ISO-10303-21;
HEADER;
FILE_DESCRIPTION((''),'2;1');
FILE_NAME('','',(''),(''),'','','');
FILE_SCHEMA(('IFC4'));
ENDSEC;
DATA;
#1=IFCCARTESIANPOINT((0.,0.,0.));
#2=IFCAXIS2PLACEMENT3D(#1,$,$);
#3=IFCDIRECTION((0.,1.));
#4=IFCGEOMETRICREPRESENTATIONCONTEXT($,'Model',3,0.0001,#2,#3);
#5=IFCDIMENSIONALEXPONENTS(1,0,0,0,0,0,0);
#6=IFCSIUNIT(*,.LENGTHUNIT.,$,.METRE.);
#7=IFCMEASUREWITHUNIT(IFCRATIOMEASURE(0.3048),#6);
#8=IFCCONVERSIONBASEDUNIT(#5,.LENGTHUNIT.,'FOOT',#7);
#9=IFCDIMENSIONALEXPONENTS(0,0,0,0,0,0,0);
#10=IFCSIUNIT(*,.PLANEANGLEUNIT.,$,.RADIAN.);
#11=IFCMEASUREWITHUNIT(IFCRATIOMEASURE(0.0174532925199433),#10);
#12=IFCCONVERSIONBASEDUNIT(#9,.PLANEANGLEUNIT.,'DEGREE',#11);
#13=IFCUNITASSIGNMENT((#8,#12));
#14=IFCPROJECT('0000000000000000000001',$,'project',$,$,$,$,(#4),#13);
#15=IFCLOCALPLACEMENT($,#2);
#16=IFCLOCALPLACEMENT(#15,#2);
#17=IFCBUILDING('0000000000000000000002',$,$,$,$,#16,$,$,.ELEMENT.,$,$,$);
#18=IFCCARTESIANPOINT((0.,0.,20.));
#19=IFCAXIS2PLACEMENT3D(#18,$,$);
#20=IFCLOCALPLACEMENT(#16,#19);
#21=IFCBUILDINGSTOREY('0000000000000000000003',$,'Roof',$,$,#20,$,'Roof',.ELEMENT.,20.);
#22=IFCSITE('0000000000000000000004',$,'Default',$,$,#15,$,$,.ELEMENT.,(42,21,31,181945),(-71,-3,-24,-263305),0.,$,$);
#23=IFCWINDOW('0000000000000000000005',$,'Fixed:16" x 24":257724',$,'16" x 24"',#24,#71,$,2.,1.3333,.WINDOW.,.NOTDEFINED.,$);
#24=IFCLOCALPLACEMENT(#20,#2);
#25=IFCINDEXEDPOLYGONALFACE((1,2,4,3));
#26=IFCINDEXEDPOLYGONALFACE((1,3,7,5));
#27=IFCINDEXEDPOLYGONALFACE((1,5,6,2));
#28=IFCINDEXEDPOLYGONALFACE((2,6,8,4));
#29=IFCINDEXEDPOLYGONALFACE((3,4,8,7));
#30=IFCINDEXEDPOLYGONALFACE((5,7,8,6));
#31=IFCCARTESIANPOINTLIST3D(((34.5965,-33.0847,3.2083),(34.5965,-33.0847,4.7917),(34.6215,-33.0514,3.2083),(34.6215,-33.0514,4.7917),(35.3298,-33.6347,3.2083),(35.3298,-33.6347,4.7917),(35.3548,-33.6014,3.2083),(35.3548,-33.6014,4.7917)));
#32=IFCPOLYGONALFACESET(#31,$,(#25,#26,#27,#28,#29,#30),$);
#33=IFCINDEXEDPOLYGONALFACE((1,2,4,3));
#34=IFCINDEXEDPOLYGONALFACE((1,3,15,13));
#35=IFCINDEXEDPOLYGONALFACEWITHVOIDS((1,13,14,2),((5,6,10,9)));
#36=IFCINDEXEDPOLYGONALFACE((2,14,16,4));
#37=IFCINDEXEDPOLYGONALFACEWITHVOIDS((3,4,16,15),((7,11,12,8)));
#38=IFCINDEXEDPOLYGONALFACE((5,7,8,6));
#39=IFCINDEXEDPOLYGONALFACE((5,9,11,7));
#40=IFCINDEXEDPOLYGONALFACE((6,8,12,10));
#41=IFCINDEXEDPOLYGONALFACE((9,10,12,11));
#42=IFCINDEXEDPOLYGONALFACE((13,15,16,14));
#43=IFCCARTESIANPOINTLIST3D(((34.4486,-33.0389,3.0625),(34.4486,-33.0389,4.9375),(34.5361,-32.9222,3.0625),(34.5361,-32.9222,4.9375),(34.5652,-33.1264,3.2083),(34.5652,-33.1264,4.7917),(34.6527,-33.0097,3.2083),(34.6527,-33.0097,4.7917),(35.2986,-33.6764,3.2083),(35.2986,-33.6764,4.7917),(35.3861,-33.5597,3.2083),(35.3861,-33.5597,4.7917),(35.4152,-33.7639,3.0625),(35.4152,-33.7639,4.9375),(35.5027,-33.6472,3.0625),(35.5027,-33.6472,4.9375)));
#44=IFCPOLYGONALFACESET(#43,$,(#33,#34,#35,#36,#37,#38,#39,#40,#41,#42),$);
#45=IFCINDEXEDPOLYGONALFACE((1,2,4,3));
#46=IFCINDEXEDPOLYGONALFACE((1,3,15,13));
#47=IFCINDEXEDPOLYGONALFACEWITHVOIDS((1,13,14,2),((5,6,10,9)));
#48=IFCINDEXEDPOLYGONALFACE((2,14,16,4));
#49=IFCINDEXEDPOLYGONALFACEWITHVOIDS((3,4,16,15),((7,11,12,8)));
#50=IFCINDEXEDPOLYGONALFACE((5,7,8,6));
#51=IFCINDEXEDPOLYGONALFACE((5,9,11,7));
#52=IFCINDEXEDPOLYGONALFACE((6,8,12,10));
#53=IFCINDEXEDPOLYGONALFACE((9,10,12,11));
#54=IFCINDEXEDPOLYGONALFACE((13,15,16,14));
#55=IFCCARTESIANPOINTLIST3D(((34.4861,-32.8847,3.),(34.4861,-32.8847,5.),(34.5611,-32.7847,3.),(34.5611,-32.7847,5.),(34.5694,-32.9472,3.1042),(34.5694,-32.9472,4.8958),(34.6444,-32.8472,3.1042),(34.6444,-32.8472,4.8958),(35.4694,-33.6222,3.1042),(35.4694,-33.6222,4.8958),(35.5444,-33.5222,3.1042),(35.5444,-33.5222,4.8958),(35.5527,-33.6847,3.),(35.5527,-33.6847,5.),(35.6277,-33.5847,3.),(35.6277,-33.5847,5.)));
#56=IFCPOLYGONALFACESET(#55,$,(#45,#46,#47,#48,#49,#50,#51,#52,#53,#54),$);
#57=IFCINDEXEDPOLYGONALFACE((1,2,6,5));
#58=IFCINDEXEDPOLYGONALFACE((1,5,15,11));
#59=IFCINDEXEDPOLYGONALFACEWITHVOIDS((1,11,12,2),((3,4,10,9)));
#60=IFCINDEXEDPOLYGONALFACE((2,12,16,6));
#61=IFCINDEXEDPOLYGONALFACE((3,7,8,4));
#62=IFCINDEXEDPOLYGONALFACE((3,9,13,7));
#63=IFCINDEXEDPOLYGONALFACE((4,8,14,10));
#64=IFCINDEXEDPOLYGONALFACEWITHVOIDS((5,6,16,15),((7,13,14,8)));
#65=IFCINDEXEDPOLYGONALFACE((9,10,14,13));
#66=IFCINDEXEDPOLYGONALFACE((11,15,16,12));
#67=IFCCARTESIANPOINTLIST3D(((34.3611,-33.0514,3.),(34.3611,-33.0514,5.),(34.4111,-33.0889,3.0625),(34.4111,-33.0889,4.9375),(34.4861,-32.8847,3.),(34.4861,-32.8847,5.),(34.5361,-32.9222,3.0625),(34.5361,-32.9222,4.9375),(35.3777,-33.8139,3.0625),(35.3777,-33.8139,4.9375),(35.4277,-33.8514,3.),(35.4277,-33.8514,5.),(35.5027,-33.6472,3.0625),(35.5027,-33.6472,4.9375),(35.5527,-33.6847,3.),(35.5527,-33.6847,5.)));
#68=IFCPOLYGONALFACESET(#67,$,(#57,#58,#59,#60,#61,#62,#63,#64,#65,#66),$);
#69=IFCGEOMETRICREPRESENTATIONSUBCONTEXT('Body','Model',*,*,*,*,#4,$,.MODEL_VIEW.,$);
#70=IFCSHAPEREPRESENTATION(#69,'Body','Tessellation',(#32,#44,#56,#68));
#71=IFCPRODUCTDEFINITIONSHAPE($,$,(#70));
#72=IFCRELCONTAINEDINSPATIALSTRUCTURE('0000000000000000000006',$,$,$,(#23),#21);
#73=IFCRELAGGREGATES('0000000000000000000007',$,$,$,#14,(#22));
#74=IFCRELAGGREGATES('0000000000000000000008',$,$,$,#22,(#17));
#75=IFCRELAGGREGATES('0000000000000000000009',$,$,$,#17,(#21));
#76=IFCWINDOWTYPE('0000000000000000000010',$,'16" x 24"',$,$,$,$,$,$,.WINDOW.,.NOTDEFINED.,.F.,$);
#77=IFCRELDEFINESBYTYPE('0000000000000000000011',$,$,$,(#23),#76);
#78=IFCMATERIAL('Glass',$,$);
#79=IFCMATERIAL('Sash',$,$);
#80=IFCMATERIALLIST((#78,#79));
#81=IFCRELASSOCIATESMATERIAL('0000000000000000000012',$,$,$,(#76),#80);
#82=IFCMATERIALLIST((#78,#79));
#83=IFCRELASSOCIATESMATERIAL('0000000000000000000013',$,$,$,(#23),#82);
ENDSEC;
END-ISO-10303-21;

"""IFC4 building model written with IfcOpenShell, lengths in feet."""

from ifc_helpers import new_model, entity, si_unit, converted_unit, direction, frame, origin, origin_2d_with_axis, place, context, subcontext, project, spatial, polyline, rectangle, outline, extrude, source, transform, mapped, material, material_list, type_object, type_shapes, element, save


model = new_model("IFC4")

# Units and contexts
model_context = context("Model", 3, precision=0.0001, world=origin(), true_north=direction((0.0, 1.0)))
body_context = subcontext(model_context, "Body", "Model", "MODEL_VIEW")
ifc_project = project(units=[converted_unit("LENGTHUNIT", "FOOT", entity("IfcRatioMeasure", 0.3048), si_unit("LENGTHUNIT", "METRE"), dimensions=[1, 0, 0, 0, 0, 0, 0]), converted_unit("PLANEANGLEUNIT", "DEGREE", entity("IfcRatioMeasure", 0.0174532925199433), si_unit("PLANEANGLEUNIT", "RADIAN"), dimensions=[0, 0, 0, 0, 0, 0, 0])], contexts=[model_context])

# Site, building, storey
site_placement = place(None, origin())
site = spatial("IfcSite", under=ifc_project, at=site_placement, Name="Default", CompositionType="ELEMENT", RefLatitude=(42, 21, 31, 181945), RefLongitude=(-71, -3, -24, -263305), RefElevation=0.0)
building_placement = place(site_placement, origin())
building = spatial("IfcBuilding", under=site, at=building_placement, CompositionType="ELEMENT")
storey_placement = place(building_placement, frame((0.0, 0.0, 20.0)))
storey = spatial("IfcBuildingStorey", under=building, at=storey_placement, Name="Roof", LongName="Roof", CompositionType="ELEMENT", Elevation=20.0)

# Window
ifc_material_1 = material(Name="Glass")
ifc_material_2 = material(Name="Sash")
ifc_material_list_1 = material_list([ifc_material_1, ifc_material_2])
ifc_material_list_2 = material_list([ifc_material_1, ifc_material_2])
window_type = type_object("IfcWindowType", Name="16\" x 24\"", ParameterTakesPrecedence=False, PartitioningType="NOTDEFINED", PredefinedType="WINDOW", material=ifc_material_list_2)
shared_shape = source(origin(), body_context, "Body", "SweptSolid", [
    extrude(rectangle(XDim=0.0417, YDim=0.9167, at=origin_2d_with_axis()), frame((0.6667, 0.1979, 0.2083), z_axis=(0.0, 0.0, 1.0), x_axis=(0.0, 1.0, 0.0)), (0.0, 0.0, 1.0), 1.5833),
    extrude(outline(polyline([(-0.6042, -0.9375), (0.6042, -0.9375), (0.6042, 0.9375), (-0.6042, 0.9375), (-0.6042, -0.9375)]), holes=[polyline([(-0.4583, -0.7917), (-0.4583, 0.7917), (0.4583, 0.7917), (0.4583, -0.7917), (-0.4583, -0.7917)])]), frame((0.6667, 0.125, 1.0), z_axis=(0.0, 1.0, 0.0), x_axis=(1.0, 0.0, 0.0)), (0.0, 0.0, 1.0), 0.1458),
    extrude(outline(polyline([(-0.6667, -1.0), (0.6667, -1.0), (0.6667, 1.0), (-0.6667, 1.0), (-0.6667, -1.0)]), holes=[polyline([(-0.5625, -0.8958), (-0.5625, 0.8958), (0.5625, 0.8958), (0.5625, -0.8958), (-0.5625, -0.8958)])]), frame((0.6667, 0.0, 1.0), z_axis=(0.0, 1.0, 0.0), x_axis=(1.0, 0.0, 0.0)), (0.0, 0.0, 1.0), 0.125),
    extrude(outline(polyline([(-1.0, -0.6667), (1.0, -0.6667), (1.0, 0.6667), (-1.0, 0.6667), (-1.0, -0.6667)]), holes=[polyline([(-0.9375, -0.6042), (-0.9375, 0.6042), (0.9375, 0.6042), (0.9375, -0.6042), (-0.9375, -0.6042)])]), frame((0.6667, 0.125, 1.0), z_axis=(0.0, 1.0, 0.0), x_axis=(0.0, 0.0, -1.0)), (0.0, 0.0, 1.0), 0.2083),
])
type_shapes(window_type, [shared_shape])
placement_1 = place(storey_placement, frame((47.9059, -43.0017, 0.0), z_axis=(0.0, 0.0, 1.0), x_axis=(-0.8, 0.6, 0.0)))
placement_2 = place(placement_1, frame((15.4728, -0.1667, 3.0)))
window_placement = place(placement_2, origin())
element("IfcWindow", 1, at=window_placement, inside=storey, type_object=window_type, material=ifc_material_list_1, Name="Fixed:16\" x 24\":257724", ObjectType="16\" x 24\"", OverallHeight=2.0, OverallWidth=1.3333, PartitioningType="NOTDEFINED", PredefinedType="WINDOW", context=body_context, shape_type="MappedRepresentation", body=[
    mapped(shared_shape, transform((0.0, 0.0, 0.0), scale=1.0)),
])

save(model, "model.ifc")
